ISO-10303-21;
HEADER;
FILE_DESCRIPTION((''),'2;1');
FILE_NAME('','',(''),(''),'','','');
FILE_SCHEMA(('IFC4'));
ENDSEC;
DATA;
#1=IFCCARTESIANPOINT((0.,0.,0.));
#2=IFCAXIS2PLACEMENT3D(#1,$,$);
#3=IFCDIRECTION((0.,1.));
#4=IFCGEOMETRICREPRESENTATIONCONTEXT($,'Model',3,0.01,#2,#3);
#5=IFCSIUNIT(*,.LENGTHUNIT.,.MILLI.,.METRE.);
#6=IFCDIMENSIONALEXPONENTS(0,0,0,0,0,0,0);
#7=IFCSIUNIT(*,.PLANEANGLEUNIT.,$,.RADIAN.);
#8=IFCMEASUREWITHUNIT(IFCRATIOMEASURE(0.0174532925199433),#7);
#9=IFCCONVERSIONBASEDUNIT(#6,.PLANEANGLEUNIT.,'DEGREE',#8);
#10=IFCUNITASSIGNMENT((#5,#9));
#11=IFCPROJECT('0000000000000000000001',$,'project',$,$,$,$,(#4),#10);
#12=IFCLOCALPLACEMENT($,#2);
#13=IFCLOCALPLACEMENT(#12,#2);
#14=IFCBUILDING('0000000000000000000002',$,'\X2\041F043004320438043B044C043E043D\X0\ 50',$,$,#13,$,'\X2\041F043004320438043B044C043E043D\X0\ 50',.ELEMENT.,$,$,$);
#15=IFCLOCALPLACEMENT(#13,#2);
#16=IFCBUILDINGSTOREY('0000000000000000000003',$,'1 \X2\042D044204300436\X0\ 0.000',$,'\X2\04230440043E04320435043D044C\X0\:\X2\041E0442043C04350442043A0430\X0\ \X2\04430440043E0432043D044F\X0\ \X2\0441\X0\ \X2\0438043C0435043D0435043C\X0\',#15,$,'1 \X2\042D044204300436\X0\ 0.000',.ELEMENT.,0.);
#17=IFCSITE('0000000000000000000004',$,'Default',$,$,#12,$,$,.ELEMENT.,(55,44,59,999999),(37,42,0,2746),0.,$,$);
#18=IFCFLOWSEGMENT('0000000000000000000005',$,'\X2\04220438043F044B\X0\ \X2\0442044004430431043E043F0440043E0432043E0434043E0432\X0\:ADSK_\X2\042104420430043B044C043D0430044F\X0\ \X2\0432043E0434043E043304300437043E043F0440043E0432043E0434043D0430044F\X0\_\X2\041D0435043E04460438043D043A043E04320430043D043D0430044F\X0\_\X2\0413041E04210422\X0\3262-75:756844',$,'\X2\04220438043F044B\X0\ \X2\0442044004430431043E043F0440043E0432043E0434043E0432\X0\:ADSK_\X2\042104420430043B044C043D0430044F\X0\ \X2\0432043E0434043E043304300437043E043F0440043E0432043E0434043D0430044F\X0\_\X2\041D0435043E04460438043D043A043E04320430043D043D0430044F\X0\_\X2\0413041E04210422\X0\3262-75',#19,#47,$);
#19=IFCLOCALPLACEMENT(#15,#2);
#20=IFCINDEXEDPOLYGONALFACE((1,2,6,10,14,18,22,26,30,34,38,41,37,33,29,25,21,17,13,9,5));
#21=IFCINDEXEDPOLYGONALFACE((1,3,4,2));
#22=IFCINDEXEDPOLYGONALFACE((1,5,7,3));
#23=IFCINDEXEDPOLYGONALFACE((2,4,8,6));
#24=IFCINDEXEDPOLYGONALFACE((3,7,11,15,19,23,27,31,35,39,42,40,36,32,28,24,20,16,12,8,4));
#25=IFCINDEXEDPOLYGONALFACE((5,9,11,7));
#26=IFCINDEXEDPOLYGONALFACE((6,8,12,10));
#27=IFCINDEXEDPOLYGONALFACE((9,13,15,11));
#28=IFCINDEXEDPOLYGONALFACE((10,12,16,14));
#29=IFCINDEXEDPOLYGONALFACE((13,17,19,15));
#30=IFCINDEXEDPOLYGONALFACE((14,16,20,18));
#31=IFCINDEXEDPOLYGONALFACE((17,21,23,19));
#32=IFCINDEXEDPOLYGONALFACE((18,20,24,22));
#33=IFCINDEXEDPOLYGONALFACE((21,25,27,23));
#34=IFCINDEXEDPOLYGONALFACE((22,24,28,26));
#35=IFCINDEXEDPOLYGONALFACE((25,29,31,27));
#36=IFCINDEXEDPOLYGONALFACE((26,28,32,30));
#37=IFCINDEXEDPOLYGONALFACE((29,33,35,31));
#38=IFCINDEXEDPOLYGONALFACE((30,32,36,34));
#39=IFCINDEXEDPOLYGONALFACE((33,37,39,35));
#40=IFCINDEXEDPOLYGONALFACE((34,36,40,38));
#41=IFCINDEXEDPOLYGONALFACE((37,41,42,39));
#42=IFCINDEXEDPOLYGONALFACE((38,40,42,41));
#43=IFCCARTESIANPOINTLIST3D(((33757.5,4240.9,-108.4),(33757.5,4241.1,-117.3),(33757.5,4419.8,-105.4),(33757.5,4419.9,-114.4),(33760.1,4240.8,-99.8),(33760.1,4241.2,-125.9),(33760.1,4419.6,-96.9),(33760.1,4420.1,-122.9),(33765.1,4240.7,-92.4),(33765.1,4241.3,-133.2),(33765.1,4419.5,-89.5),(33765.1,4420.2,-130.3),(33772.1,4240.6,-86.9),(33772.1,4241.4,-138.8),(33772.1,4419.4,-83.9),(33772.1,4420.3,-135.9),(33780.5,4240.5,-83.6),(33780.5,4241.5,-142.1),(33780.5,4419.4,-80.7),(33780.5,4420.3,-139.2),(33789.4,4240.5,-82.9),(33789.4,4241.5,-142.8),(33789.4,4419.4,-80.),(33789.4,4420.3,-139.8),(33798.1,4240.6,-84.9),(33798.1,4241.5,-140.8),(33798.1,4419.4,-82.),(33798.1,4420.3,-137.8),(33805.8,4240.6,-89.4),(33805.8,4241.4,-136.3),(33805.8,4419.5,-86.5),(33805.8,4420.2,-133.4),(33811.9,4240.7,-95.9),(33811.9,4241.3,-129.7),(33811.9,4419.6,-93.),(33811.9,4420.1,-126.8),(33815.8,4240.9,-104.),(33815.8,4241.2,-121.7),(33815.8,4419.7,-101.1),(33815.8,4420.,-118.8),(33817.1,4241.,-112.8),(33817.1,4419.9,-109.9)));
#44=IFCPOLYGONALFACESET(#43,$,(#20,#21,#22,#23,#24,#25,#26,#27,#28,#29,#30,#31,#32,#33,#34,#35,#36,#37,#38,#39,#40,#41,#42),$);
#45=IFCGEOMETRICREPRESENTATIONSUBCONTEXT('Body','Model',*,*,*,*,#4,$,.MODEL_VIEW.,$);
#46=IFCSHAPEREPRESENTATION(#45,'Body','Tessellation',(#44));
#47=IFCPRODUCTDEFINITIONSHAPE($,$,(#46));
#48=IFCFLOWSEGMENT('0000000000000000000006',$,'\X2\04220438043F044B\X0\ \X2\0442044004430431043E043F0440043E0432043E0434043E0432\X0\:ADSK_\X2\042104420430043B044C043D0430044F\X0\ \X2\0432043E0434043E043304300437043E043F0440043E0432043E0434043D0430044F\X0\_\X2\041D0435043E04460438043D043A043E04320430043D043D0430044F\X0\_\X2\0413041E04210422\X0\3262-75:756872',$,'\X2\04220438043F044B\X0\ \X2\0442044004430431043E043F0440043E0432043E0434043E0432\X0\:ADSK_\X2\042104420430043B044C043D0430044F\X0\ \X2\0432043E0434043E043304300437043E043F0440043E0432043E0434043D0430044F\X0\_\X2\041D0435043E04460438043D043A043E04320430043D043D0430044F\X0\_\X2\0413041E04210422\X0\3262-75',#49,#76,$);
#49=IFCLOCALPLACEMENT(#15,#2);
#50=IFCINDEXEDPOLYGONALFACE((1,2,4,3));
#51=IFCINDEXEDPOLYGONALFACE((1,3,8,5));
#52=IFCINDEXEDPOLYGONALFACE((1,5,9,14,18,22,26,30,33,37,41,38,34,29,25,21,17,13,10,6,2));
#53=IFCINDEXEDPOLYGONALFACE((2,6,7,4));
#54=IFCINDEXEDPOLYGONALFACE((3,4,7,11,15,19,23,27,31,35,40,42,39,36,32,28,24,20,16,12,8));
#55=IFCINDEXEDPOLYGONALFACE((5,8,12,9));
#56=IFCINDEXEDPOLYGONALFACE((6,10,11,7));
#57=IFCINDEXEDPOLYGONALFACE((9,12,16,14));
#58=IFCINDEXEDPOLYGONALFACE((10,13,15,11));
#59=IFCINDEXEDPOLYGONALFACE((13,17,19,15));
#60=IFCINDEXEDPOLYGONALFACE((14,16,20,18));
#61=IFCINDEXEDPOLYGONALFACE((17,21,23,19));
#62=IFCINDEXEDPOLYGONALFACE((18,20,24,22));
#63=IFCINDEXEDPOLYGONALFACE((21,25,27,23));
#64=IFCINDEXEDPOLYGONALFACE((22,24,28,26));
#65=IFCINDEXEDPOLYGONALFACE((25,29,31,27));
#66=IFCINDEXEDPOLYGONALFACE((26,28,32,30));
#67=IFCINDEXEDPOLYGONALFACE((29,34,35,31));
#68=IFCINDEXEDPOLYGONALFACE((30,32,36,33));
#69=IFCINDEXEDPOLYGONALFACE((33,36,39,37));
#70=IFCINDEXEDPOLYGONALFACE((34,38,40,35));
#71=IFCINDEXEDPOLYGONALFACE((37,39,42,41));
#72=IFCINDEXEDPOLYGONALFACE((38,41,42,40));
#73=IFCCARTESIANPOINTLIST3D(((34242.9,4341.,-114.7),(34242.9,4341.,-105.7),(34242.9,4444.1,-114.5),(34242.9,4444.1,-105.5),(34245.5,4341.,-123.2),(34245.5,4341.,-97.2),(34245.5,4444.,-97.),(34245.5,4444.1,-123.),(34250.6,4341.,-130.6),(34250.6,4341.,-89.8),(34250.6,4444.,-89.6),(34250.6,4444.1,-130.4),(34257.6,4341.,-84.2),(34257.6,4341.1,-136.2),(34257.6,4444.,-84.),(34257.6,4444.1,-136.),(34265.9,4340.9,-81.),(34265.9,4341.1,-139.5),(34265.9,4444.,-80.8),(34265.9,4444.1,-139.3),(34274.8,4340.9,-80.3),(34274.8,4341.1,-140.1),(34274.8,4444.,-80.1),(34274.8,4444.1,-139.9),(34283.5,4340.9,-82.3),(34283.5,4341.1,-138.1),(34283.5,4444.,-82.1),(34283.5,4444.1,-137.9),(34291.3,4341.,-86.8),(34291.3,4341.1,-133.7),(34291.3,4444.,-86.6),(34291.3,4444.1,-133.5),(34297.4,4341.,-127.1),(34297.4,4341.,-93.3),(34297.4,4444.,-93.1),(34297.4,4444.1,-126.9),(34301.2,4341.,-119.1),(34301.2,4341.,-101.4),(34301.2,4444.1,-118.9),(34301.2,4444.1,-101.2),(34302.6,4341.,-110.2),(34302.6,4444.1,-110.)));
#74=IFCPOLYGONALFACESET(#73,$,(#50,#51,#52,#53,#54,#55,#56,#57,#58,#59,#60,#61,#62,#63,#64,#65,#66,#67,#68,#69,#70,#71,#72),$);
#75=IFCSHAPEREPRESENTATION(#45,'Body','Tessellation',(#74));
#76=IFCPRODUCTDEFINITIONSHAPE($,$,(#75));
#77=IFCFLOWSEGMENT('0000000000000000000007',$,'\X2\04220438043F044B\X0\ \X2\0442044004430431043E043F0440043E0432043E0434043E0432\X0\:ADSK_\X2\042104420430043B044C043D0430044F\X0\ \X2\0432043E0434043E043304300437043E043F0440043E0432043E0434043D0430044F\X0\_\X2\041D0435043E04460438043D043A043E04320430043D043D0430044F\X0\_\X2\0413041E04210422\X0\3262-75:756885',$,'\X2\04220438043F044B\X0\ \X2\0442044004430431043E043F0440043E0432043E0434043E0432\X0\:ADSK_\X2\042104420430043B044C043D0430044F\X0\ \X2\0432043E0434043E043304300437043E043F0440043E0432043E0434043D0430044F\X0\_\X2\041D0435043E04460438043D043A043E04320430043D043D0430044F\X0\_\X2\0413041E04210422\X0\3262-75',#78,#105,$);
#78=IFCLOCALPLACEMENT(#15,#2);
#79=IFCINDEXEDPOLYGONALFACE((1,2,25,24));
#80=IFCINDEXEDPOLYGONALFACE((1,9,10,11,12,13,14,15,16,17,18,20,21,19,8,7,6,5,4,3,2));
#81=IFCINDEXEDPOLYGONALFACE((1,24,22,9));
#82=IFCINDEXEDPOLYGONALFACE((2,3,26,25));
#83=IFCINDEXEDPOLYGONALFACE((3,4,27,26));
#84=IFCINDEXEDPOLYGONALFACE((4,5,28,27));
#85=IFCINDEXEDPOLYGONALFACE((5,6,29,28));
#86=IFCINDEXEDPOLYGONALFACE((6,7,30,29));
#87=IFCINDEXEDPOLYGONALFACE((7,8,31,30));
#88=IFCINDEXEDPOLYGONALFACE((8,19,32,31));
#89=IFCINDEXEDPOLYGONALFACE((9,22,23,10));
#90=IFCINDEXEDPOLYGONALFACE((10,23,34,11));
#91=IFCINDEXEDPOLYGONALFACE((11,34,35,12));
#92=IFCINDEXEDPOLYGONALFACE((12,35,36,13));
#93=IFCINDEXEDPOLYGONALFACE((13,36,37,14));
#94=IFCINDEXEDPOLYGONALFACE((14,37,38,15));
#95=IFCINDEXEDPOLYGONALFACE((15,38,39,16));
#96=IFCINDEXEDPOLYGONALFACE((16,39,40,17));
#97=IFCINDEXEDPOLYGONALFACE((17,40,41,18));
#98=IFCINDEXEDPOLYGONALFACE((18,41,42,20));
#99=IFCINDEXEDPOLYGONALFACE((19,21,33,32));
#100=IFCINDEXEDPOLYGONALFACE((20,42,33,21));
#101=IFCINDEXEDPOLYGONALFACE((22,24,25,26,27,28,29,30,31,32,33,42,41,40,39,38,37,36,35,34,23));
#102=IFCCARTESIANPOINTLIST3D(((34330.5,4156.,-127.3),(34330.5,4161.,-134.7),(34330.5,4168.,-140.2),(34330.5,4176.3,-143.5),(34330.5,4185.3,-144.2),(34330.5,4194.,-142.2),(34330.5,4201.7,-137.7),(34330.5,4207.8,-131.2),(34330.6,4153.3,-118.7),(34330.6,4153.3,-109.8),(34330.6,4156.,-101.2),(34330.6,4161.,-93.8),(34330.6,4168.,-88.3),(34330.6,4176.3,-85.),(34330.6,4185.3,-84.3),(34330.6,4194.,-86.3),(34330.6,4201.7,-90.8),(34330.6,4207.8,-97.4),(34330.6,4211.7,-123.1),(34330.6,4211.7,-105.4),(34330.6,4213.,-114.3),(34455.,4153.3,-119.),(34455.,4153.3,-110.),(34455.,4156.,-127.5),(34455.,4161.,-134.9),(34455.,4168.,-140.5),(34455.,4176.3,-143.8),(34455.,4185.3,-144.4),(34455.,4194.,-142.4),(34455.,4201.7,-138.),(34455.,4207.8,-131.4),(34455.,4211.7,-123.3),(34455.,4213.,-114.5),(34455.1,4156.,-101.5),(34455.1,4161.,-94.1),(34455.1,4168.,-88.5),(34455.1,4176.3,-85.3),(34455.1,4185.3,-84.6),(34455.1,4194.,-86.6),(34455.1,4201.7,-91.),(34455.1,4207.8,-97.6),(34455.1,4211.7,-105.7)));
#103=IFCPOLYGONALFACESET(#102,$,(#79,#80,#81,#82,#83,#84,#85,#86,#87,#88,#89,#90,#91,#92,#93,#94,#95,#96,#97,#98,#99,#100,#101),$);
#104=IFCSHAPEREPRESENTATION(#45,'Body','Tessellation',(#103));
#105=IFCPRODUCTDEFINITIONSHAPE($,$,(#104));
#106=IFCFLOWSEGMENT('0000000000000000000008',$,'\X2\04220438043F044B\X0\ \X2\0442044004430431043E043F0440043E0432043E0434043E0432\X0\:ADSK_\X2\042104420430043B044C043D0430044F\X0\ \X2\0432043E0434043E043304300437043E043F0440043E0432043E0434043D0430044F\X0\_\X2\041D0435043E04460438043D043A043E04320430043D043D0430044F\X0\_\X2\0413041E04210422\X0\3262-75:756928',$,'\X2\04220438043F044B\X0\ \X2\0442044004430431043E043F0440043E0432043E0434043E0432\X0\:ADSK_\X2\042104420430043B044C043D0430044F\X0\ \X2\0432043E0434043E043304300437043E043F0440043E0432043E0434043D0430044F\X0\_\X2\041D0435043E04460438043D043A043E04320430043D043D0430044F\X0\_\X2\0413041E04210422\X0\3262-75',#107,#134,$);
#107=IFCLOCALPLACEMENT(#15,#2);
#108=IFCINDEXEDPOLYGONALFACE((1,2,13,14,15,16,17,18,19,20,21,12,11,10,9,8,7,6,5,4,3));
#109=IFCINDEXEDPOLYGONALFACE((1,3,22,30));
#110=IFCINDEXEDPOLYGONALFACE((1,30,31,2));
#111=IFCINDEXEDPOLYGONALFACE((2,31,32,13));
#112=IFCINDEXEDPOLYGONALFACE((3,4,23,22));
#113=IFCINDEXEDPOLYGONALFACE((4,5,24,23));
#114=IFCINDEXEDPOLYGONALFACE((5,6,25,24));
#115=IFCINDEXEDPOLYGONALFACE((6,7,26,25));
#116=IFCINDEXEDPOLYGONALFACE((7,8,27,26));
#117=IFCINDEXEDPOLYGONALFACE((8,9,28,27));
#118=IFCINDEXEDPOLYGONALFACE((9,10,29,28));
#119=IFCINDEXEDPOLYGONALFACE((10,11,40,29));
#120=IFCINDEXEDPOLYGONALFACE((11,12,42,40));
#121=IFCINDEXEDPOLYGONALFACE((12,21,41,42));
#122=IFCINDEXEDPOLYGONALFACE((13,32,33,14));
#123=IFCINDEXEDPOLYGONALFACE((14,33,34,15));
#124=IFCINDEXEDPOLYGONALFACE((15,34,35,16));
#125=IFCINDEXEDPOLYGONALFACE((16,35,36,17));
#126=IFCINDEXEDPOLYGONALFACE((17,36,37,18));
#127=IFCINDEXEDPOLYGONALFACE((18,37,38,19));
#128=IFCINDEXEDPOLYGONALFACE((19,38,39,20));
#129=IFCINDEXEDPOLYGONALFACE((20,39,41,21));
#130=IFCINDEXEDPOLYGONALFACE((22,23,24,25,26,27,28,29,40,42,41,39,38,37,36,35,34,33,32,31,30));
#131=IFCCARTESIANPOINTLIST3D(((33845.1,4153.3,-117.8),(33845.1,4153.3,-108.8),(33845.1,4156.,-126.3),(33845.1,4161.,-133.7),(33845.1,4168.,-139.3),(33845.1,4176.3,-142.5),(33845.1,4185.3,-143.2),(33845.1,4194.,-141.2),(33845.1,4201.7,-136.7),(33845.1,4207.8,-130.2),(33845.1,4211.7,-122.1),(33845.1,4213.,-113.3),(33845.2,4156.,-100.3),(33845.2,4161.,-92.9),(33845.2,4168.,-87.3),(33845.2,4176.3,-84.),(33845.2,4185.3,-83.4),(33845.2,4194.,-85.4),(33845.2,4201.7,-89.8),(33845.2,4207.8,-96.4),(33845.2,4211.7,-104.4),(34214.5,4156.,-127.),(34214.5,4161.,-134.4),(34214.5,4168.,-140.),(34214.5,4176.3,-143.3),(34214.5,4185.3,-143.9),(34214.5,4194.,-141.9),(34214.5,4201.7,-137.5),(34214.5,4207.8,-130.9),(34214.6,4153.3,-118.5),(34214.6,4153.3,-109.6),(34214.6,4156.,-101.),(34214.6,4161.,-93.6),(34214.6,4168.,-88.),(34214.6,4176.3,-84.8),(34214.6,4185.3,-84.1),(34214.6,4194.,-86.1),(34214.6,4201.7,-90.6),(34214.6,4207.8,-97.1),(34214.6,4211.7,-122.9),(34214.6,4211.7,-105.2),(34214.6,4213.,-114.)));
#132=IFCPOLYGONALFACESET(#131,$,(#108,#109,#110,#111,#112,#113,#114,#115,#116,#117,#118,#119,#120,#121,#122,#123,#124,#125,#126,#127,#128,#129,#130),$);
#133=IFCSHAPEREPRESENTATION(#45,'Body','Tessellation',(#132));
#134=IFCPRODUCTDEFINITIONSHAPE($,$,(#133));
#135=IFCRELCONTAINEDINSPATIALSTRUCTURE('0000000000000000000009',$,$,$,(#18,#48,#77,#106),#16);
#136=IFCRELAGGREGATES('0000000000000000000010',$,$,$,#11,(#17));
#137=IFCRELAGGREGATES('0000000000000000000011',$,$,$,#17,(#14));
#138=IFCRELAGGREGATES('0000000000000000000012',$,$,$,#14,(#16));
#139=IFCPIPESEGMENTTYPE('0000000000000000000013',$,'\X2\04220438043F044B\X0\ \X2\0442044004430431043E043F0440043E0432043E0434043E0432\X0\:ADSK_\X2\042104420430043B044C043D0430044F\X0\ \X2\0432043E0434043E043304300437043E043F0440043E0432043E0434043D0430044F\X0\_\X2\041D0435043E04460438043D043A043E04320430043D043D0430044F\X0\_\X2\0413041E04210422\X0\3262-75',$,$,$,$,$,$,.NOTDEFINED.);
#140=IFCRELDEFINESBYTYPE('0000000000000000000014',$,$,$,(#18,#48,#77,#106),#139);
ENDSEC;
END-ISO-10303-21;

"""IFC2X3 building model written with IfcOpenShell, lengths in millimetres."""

from ifc_helpers import new_model, entity, si_unit, converted_unit, direction, frame, frame_2d, origin, place, context, subcontext, project, spatial, circle, extrude, type_object, element, save


model = new_model("IFC2X3")

# Units and contexts
model_context = context("Model", 3, precision=0.01, world=origin(), true_north=direction((0.0, 1.0)))
body_context = subcontext(model_context, "Body", "Model", "MODEL_VIEW")
ifc_project = project(units=[si_unit("LENGTHUNIT", "METRE", prefix="MILLI"), converted_unit("PLANEANGLEUNIT", "DEGREE", entity("IfcRatioMeasure", 0.0174532925199433), si_unit("PLANEANGLEUNIT", "RADIAN"), dimensions=[0, 0, 0, 0, 0, 0, 0])], contexts=[model_context])

# Site, building, storey
site_placement = place(None, origin())
site = spatial("IfcSite", under=ifc_project, at=site_placement, Name="Default", CompositionType="ELEMENT", RefLatitude=(55, 44, 59, 999999), RefLongitude=(37, 42, 0, 2746), RefElevation=0.0)
building_placement = place(site_placement, origin())
building = spatial("IfcBuilding", under=site, at=building_placement, Name="Павильон 50", LongName="Павильон 50", CompositionType="ELEMENT")
storey_placement = place(building_placement, origin())
storey = spatial("IfcBuildingStorey", under=building, at=storey_placement, Name="1 Этаж 0.000", ObjectType="Уровень:Отметка уровня с именем", LongName="1 Этаж 0.000", CompositionType="ELEMENT", Elevation=0.0)

# Flow segments
pipe_segment_type = type_object("IfcPipeSegmentType", Name="Типы трубопроводов:ADSK_Стальная водогазопроводная_Неоцинкованная_ГОСТ3262-75", PredefinedType="NOTDEFINED")
flow_segment_1_placement = place(storey_placement, frame((33755.5, 4238.9, -144.4)))
element("IfcFlowSegment", 1, at=flow_segment_1_placement, inside=storey, type_object=pipe_segment_type, Name="Типы трубопроводов:ADSK_Стальная водогазопроводная_Неоцинкованная_ГОСТ3262-75:756844", ObjectType="Типы трубопроводов:ADSK_Стальная водогазопроводная_Неоцинкованная_ГОСТ3262-75", context=body_context, shape_type="SweptSolid", body=[
    extrude(circle(Radius=30.0, at=frame_2d((0.0, 0.0), x_axis=(1.0, 0.0))), frame((31.6, 2.1, 31.6), z_axis=(-0.000008, 0.999866, 0.016376), x_axis=(1.0, 0.000008, 0.0)), (0.0, 0.0, 1.0), 178.9),
])
flow_segment_2_placement = place(storey_placement, frame((34241.0, 4340.9, -141.8)))
element("IfcFlowSegment", 2, at=flow_segment_2_placement, inside=storey, type_object=pipe_segment_type, Name="Типы трубопроводов:ADSK_Стальная водогазопроводная_Неоцинкованная_ГОСТ3262-75:756872", ObjectType="Типы трубопроводов:ADSK_Стальная водогазопроводная_Неоцинкованная_ГОСТ3262-75", context=body_context, shape_type="SweptSolid", body=[
    extrude(circle(Radius=30.0, at=frame_2d((0.0, 0.0), x_axis=(1.0, 0.0))), frame((31.6, 0.1, 31.6), z_axis=(-0.000008, 0.999998, 0.002), x_axis=(1.0, 0.000008, 0.0)), (0.0, 0.0, 1.0), 103.1),
])
flow_segment_3_placement = place(storey_placement, frame((34330.5, 4151.4, -146.1)))
element("IfcFlowSegment", 3, at=flow_segment_3_placement, inside=storey, type_object=pipe_segment_type, Name="Типы трубопроводов:ADSK_Стальная водогазопроводная_Неоцинкованная_ГОСТ3262-75:756885", ObjectType="Типы трубопроводов:ADSK_Стальная водогазопроводная_Неоцинкованная_ГОСТ3262-75", context=body_context, shape_type="SweptSolid", body=[
    extrude(circle(Radius=30.0, at=frame_2d((0.0, 0.0), x_axis=(1.0, 0.0))), frame((124.5, 31.6, 31.6), z_axis=(-0.999998, 0.0, 0.002), x_axis=(0.0, 1.0, 0.0)), (0.0, 0.0, 1.0), 124.5),
])
flow_segment_4_placement = place(storey_placement, frame((33845.1, 4151.4, -145.6)))
element("IfcFlowSegment", 4, at=flow_segment_4_placement, inside=storey, type_object=pipe_segment_type, Name="Типы трубопроводов:ADSK_Стальная водогазопроводная_Неоцинкованная_ГОСТ3262-75:756928", ObjectType="Типы трубопроводов:ADSK_Стальная водогазопроводная_Неоцинкованная_ГОСТ3262-75", context=body_context, shape_type="SweptSolid", body=[
    extrude(circle(Radius=30.0, at=frame_2d((0.0, 0.0), x_axis=(1.0, 0.0))), frame((0.1, 31.6, 32.3), z_axis=(0.999998, 0.0, -0.002), x_axis=(0.0, 1.0, 0.0)), (0.0, 0.0, 1.0), 369.4),
])

save(model, "model.ifc")
